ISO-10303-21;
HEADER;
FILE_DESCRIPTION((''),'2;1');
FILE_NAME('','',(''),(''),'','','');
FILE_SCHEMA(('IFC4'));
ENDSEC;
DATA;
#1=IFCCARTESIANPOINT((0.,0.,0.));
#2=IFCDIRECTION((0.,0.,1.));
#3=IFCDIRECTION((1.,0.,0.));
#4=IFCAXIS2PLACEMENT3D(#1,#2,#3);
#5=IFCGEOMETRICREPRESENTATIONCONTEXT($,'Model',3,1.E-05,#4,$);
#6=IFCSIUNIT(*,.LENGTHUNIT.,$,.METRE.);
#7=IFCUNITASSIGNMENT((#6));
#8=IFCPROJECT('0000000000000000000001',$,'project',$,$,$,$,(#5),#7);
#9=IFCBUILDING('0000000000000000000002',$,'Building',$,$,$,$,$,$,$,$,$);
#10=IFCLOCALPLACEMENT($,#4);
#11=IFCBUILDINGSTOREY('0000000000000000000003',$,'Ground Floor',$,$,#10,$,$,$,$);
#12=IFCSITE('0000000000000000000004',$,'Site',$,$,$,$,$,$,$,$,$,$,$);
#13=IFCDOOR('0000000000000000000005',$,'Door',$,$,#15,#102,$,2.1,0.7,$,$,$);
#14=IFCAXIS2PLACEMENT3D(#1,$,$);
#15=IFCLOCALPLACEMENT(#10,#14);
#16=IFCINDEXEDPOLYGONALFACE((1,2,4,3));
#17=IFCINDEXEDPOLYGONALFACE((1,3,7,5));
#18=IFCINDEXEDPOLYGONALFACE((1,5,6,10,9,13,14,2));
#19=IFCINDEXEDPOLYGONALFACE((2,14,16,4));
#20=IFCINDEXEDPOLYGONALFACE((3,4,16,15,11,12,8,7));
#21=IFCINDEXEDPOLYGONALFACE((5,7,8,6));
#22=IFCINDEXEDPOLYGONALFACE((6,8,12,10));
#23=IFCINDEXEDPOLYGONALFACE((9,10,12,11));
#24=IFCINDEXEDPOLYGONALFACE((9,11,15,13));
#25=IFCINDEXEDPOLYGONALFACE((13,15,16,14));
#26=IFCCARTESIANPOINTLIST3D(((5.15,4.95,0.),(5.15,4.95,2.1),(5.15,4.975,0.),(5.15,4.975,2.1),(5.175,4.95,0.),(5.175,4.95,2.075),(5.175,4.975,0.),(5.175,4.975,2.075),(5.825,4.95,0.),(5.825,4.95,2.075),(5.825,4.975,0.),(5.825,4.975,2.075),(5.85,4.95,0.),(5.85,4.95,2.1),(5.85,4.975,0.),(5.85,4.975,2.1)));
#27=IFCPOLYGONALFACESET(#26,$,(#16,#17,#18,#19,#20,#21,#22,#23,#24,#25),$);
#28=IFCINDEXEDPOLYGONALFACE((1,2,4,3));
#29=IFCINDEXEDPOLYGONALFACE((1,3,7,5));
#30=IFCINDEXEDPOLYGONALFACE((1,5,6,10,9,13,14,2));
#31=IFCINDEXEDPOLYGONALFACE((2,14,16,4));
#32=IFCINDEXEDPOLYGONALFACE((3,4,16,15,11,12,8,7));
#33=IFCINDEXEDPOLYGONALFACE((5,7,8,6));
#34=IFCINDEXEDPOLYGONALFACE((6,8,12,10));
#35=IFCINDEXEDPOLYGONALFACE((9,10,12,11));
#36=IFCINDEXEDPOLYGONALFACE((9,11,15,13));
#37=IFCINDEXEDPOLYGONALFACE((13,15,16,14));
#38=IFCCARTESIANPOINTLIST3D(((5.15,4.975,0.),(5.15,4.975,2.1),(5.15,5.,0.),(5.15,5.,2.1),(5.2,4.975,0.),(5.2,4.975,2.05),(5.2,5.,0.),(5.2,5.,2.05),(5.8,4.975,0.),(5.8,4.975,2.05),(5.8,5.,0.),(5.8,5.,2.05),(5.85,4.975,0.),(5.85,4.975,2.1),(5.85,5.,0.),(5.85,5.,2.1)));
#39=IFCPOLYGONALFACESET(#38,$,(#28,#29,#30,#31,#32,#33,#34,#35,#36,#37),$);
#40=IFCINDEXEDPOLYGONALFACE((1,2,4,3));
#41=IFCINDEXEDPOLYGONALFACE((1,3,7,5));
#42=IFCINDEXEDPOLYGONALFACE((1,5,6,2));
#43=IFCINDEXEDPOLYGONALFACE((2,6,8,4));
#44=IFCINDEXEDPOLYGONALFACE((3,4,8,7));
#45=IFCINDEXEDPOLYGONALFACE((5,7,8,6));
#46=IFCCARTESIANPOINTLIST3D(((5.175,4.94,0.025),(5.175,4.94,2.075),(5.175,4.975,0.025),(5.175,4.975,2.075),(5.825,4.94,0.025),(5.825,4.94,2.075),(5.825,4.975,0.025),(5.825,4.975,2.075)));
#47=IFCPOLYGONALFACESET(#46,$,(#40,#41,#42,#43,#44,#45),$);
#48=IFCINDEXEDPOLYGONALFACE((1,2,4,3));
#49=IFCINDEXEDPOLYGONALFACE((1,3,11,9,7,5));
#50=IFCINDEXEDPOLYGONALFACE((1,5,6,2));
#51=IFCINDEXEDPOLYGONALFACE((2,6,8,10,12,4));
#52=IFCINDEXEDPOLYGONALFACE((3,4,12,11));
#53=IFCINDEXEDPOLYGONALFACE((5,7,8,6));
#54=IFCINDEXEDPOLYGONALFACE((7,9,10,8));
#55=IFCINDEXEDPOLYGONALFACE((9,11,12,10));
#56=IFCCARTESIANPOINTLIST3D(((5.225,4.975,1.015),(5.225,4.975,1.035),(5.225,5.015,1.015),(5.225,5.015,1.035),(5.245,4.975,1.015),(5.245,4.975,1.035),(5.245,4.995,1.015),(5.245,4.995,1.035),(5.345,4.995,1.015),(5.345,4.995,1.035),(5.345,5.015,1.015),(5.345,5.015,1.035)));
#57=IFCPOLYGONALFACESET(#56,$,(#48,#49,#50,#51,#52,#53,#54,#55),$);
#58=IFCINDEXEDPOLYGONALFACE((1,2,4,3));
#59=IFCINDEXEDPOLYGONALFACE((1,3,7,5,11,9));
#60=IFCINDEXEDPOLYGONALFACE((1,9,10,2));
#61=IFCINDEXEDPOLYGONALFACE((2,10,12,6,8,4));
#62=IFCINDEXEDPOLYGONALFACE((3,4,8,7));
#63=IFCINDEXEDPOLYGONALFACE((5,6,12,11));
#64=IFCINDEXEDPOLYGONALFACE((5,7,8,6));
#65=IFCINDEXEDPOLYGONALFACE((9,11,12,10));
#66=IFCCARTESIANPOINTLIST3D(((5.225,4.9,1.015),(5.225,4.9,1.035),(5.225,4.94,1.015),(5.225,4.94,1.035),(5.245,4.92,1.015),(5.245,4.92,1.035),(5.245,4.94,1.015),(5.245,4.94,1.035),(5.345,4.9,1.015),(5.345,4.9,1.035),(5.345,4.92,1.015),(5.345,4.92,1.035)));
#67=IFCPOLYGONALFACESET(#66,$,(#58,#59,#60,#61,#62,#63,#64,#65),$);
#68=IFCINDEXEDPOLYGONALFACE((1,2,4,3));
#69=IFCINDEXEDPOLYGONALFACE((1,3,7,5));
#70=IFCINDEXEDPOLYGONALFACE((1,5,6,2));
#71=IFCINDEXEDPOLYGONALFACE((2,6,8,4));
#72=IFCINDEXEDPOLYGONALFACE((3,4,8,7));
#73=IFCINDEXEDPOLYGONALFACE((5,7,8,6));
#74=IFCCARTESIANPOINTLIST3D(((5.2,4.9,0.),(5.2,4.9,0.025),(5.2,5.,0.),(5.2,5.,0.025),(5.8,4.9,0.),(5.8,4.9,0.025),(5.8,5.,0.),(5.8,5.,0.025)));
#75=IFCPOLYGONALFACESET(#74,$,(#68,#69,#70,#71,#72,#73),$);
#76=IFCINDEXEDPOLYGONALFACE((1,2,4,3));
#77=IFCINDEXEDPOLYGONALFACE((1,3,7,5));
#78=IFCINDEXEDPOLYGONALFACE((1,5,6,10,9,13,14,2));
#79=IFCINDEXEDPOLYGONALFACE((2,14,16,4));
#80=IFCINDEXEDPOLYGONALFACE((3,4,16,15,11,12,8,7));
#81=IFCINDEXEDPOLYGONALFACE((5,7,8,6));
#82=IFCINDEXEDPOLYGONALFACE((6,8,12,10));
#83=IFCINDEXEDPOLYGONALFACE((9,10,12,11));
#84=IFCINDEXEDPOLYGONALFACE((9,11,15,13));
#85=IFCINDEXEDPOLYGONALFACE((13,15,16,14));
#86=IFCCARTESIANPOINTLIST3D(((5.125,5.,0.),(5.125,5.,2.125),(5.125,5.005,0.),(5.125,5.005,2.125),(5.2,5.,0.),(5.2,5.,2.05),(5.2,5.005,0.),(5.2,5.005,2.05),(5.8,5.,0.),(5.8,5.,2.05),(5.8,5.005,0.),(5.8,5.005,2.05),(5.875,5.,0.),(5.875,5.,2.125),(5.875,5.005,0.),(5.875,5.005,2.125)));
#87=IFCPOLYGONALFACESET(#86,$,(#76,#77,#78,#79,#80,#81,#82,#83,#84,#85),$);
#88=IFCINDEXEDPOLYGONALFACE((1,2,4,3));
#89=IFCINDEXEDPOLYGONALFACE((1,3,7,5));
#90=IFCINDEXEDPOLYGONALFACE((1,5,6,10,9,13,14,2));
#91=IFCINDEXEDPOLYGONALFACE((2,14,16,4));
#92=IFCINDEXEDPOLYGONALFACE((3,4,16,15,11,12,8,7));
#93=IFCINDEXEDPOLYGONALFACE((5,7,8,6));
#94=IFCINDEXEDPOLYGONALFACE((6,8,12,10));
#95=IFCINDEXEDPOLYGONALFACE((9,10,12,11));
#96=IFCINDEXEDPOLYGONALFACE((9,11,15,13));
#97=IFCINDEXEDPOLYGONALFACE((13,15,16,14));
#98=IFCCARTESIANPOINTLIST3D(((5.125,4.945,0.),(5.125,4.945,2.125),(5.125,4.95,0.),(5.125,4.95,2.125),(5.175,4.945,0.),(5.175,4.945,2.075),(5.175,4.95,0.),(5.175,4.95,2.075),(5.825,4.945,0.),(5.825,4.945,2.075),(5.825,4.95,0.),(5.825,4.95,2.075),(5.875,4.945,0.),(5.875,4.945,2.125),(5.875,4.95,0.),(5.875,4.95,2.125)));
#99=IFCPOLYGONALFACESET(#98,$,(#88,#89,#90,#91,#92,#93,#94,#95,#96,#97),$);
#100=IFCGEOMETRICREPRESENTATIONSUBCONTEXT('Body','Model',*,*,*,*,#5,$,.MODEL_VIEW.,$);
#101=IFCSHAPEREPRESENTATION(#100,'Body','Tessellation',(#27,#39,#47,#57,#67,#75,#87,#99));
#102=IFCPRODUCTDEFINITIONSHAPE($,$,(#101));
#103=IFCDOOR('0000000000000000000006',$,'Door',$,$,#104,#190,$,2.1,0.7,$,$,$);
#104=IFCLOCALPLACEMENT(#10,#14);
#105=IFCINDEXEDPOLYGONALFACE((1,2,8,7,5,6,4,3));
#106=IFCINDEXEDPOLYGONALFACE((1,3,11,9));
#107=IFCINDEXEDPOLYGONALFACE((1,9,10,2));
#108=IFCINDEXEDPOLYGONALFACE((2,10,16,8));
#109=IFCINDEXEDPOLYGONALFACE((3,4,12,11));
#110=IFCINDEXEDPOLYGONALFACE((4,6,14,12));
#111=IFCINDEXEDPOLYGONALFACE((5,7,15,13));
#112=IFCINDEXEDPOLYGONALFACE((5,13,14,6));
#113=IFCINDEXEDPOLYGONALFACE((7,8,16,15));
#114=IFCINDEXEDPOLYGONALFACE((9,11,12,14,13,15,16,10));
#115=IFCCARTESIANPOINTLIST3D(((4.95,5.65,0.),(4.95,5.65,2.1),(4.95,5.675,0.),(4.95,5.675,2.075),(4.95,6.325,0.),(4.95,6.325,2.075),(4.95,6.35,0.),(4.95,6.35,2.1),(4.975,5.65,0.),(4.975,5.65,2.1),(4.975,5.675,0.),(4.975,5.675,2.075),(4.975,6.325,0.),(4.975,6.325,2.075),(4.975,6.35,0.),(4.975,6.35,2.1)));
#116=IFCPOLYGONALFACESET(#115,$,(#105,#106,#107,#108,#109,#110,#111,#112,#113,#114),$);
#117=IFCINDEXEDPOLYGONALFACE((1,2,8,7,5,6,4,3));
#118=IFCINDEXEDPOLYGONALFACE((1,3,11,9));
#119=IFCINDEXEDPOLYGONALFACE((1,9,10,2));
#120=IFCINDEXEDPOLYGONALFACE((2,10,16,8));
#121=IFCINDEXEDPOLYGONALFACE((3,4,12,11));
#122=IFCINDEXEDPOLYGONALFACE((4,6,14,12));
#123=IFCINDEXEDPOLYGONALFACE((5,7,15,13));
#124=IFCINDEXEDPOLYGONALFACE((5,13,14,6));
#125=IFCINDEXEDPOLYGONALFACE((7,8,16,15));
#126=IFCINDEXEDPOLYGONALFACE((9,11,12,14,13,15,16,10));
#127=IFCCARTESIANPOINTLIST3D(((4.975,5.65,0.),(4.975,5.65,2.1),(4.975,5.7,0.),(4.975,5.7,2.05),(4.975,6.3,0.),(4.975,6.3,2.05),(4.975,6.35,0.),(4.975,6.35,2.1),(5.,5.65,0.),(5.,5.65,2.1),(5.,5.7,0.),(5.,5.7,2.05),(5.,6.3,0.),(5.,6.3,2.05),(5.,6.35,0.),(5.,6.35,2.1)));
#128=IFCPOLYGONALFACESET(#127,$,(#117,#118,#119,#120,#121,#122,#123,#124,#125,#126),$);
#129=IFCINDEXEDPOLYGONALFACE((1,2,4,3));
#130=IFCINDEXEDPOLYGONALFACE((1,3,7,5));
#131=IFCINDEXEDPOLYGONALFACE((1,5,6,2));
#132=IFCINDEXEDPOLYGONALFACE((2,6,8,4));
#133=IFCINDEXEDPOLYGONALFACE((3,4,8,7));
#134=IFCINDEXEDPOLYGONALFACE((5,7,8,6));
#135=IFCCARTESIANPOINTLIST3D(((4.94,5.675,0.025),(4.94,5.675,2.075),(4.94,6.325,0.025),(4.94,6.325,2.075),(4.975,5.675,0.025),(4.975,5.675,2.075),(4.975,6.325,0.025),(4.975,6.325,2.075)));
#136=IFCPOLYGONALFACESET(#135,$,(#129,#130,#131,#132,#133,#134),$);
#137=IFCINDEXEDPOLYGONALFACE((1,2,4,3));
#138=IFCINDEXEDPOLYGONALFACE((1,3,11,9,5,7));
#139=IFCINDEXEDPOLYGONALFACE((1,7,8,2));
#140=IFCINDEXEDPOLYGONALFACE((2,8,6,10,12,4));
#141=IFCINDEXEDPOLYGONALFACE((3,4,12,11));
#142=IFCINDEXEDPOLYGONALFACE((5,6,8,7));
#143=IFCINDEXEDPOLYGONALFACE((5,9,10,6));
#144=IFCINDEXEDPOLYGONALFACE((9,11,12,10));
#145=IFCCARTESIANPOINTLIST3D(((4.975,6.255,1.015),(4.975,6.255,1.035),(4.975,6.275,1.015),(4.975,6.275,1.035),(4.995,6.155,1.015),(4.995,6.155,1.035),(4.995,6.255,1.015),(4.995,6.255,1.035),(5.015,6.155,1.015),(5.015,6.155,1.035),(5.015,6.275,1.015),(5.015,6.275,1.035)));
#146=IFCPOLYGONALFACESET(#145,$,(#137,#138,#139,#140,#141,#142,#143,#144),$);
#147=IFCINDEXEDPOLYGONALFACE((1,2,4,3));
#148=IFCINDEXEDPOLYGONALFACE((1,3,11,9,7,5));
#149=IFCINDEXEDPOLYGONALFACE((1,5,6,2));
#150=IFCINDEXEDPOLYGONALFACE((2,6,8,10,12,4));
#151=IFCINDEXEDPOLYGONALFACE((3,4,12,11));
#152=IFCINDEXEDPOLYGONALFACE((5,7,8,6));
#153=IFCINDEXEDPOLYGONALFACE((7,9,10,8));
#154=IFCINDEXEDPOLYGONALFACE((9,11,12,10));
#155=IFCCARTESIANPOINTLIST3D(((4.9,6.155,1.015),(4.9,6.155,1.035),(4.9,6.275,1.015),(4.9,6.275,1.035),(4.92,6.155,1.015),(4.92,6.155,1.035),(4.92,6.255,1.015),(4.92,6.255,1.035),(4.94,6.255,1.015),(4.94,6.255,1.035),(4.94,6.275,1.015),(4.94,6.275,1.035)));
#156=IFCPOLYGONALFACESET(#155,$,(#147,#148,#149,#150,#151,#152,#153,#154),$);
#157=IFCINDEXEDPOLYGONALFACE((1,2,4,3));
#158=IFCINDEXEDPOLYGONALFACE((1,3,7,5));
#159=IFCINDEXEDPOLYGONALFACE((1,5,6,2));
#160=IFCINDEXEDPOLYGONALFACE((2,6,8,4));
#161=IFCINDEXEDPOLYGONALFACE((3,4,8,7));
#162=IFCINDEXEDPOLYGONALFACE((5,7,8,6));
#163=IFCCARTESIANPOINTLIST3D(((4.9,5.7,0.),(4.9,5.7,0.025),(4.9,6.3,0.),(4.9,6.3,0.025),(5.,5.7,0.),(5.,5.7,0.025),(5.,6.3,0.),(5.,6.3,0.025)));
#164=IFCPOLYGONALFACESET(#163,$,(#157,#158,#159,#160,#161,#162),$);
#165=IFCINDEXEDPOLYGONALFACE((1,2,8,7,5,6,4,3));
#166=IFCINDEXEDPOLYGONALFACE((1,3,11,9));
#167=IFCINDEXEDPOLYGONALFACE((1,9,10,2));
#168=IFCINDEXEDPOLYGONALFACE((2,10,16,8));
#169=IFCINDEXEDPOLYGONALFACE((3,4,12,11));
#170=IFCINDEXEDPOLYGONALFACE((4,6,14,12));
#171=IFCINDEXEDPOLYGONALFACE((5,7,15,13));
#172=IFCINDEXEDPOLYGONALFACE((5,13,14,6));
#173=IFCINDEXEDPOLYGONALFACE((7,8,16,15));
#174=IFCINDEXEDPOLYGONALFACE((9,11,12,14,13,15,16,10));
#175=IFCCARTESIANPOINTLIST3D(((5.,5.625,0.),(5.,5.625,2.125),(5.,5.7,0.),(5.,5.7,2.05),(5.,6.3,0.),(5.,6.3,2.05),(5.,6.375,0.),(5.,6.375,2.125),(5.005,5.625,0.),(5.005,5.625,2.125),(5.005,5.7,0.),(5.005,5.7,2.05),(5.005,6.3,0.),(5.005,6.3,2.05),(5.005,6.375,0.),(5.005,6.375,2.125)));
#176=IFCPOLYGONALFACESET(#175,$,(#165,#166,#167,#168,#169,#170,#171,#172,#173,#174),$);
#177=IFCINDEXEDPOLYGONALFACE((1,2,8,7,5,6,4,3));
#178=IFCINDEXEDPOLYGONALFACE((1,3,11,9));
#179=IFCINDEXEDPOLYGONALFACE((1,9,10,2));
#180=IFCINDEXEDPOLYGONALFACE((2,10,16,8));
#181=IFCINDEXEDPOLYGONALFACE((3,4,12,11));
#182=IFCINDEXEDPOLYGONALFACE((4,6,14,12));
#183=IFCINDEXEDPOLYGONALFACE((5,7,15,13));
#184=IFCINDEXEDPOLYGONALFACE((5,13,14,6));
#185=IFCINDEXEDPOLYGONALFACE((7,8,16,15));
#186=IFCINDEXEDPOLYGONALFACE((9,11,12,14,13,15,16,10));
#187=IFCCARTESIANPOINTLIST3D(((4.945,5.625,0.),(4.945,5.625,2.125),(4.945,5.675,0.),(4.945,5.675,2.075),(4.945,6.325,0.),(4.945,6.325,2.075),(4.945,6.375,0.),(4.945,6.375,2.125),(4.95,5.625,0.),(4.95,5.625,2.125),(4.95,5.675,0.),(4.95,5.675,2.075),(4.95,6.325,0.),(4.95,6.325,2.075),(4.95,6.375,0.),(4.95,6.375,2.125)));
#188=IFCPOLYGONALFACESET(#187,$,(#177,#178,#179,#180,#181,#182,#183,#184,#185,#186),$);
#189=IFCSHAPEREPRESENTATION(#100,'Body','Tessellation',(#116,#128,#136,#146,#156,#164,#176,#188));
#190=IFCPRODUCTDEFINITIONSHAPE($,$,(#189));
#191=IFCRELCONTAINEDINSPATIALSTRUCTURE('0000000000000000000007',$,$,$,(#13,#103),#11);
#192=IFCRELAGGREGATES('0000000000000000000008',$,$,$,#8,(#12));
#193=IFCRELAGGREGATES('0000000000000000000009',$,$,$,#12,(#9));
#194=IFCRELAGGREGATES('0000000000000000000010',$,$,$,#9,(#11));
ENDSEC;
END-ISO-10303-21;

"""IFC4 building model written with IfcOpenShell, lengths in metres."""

from ifc_helpers import new_model, si_unit, frame, origin_with_axes, place, context, subcontext, project, spatial, line, indexed_curve, outline, extrude, element, save


model = new_model("IFC4")

# Units and contexts
model_context = context("Model", 3, precision=1e-05, world=origin_with_axes())
body_context = subcontext(model_context, "Body", "Model", "MODEL_VIEW")
ifc_project = project(units=[si_unit("LENGTHUNIT", "METRE")], contexts=[model_context])

# Site, building, storey
site = spatial("IfcSite", under=ifc_project, Name="Site")
building = spatial("IfcBuilding", under=site, Name="Building")
storey_placement = place(None, origin_with_axes())
storey = spatial("IfcBuildingStorey", under=building, at=storey_placement, Name="Ground Floor")

# Doors
door_1_placement = place(storey_placement, frame((5.85, 5.0, 0.0), z_axis=(0.0, 0.0, 1.0), x_axis=(-1.0, 0.0, 0.0)))
element("IfcDoor", 1, at=door_1_placement, inside=storey, Name="Door", OverallHeight=2.1, OverallWidth=0.7, context=body_context, shape_type="SweptSolid", body=[
    extrude(outline(indexed_curve([(0.0, 0.0), (0.0, 2.1), (0.7, 2.1), (0.7, 0.0), (0.675, 0.0), (0.675, 2.075), (0.025, 2.075), (0.025, 0.0)], segments=[line(1, 2, 3, 4, 5, 6, 7, 8, 1)])), frame((0.0, 0.025, 0.0), z_axis=(0.0, -1.0, 0.0), x_axis=(1.0, 0.0, 0.0)), (0.0, 0.0, -1.0), 0.025),
    extrude(outline(indexed_curve([(0.0, 0.0), (0.0, 2.1), (0.7, 2.1), (0.7, 0.0), (0.65, 0.0), (0.65, 2.05), (0.05, 2.05), (0.05, 0.0)], segments=[line(1, 2, 3, 4, 5, 6, 7, 8, 1)])), frame((0.0, 0.0, 0.0), z_axis=(0.0, -1.0, 0.0), x_axis=(1.0, 0.0, 0.0)), (0.0, 0.0, -1.0), 0.025),
    extrude(outline(indexed_curve([(0.0, 0.0), (0.65, 0.0), (0.65, 0.035), (0.0, 0.035)], segments=[line(1, 2, 3, 4, 1)])), frame((0.025, 0.025, 0.025), z_axis=(0.0, 0.0, 1.0), x_axis=(1.0, 0.0, 0.0)), (0.0, 0.0, 1.0), 2.05),
    extrude(outline(indexed_curve([(0.0, 0.0), (0.0, -0.04), (-0.12, -0.04), (-0.12, -0.02), (-0.02, -0.02), (-0.02, 0.0)], segments=[line(1, 2, 3, 4, 5, 6, 1)])), frame((0.625, 0.025, 1.015), z_axis=(0.0, 0.0, 1.0), x_axis=(1.0, 0.0, 0.0)), (0.0, 0.0, 1.0), 0.02),
    extrude(outline(indexed_curve([(0.0, 0.0), (0.0, 0.04), (-0.12, 0.04), (-0.12, 0.02), (-0.02, 0.02), (-0.02, 0.0)], segments=[line(1, 2, 3, 4, 5, 6, 1)])), frame((0.625, 0.06, 1.015), z_axis=(0.0, 0.0, 1.0), x_axis=(1.0, 0.0, 0.0)), (0.0, 0.0, 1.0), 0.02),
    extrude(outline(indexed_curve([(0.0, 0.0), (0.6, 0.0), (0.6, 0.1), (0.0, 0.1)], segments=[line(1, 2, 3, 4, 1)])), frame((0.05, 0.0, 0.0), z_axis=(0.0, 0.0, 1.0), x_axis=(1.0, 0.0, 0.0)), (0.0, 0.0, 1.0), 0.025),
    extrude(outline(indexed_curve([(0.0, 0.0), (0.0, 2.125), (0.75, 2.125), (0.75, 0.0), (0.675, 0.0), (0.675, 2.05), (0.075, 2.05), (0.075, 0.0)], segments=[line(1, 2, 3, 4, 5, 6, 7, 8, 1)])), frame((-0.025, -0.005, 0.0), z_axis=(0.0, -1.0, 0.0), x_axis=(1.0, 0.0, 0.0)), (0.0, 0.0, -1.0), 0.005),
    extrude(outline(indexed_curve([(0.0, 0.0), (0.0, 2.125), (0.75, 2.125), (0.75, 0.0), (0.7, 0.0), (0.7, 2.075), (0.05, 2.075), (0.05, 0.0)], segments=[line(1, 2, 3, 4, 5, 6, 7, 8, 1)])), frame((-0.025, 0.05, 0.0), z_axis=(0.0, -1.0, 0.0), x_axis=(1.0, 0.0, 0.0)), (0.0, 0.0, -1.0), 0.005),
])
door_2_placement = place(storey_placement, frame((5.0, 5.65, 0.0), z_axis=(0.0, 0.0, 1.0), x_axis=(0.0, 1.0, 0.0)))
element("IfcDoor", 2, at=door_2_placement, inside=storey, Name="Door", OverallHeight=2.1, OverallWidth=0.7, context=body_context, shape_type="SweptSolid", body=[
    extrude(outline(indexed_curve([(0.0, 0.0), (0.0, 2.1), (0.7, 2.1), (0.7, 0.0), (0.675, 0.0), (0.675, 2.075), (0.025, 2.075), (0.025, 0.0)], segments=[line(1, 2, 3, 4, 5, 6, 7, 8, 1)])), frame((0.0, 0.025, 0.0), z_axis=(0.0, -1.0, 0.0), x_axis=(1.0, 0.0, 0.0)), (0.0, 0.0, -1.0), 0.025),
    extrude(outline(indexed_curve([(0.0, 0.0), (0.0, 2.1), (0.7, 2.1), (0.7, 0.0), (0.65, 0.0), (0.65, 2.05), (0.05, 2.05), (0.05, 0.0)], segments=[line(1, 2, 3, 4, 5, 6, 7, 8, 1)])), frame((0.0, 0.0, 0.0), z_axis=(0.0, -1.0, 0.0), x_axis=(1.0, 0.0, 0.0)), (0.0, 0.0, -1.0), 0.025),
    extrude(outline(indexed_curve([(0.0, 0.0), (0.65, 0.0), (0.65, 0.035), (0.0, 0.035)], segments=[line(1, 2, 3, 4, 1)])), frame((0.025, 0.025, 0.025), z_axis=(0.0, 0.0, 1.0), x_axis=(1.0, 0.0, 0.0)), (0.0, 0.0, 1.0), 2.05),
    extrude(outline(indexed_curve([(0.0, 0.0), (0.0, -0.04), (-0.12, -0.04), (-0.12, -0.02), (-0.02, -0.02), (-0.02, 0.0)], segments=[line(1, 2, 3, 4, 5, 6, 1)])), frame((0.625, 0.025, 1.015), z_axis=(0.0, 0.0, 1.0), x_axis=(1.0, 0.0, 0.0)), (0.0, 0.0, 1.0), 0.02),
    extrude(outline(indexed_curve([(0.0, 0.0), (0.0, 0.04), (-0.12, 0.04), (-0.12, 0.02), (-0.02, 0.02), (-0.02, 0.0)], segments=[line(1, 2, 3, 4, 5, 6, 1)])), frame((0.625, 0.06, 1.015), z_axis=(0.0, 0.0, 1.0), x_axis=(1.0, 0.0, 0.0)), (0.0, 0.0, 1.0), 0.02),
    extrude(outline(indexed_curve([(0.0, 0.0), (0.6, 0.0), (0.6, 0.1), (0.0, 0.1)], segments=[line(1, 2, 3, 4, 1)])), frame((0.05, 0.0, 0.0), z_axis=(0.0, 0.0, 1.0), x_axis=(1.0, 0.0, 0.0)), (0.0, 0.0, 1.0), 0.025),
    extrude(outline(indexed_curve([(0.0, 0.0), (0.0, 2.125), (0.75, 2.125), (0.75, 0.0), (0.675, 0.0), (0.675, 2.05), (0.075, 2.05), (0.075, 0.0)], segments=[line(1, 2, 3, 4, 5, 6, 7, 8, 1)])), frame((-0.025, -0.005, 0.0), z_axis=(0.0, -1.0, 0.0), x_axis=(1.0, 0.0, 0.0)), (0.0, 0.0, -1.0), 0.005),
    extrude(outline(indexed_curve([(0.0, 0.0), (0.0, 2.125), (0.75, 2.125), (0.75, 0.0), (0.7, 0.0), (0.7, 2.075), (0.05, 2.075), (0.05, 0.0)], segments=[line(1, 2, 3, 4, 5, 6, 7, 8, 1)])), frame((-0.025, 0.05, 0.0), z_axis=(0.0, -1.0, 0.0), x_axis=(1.0, 0.0, 0.0)), (0.0, 0.0, -1.0), 0.005),
])

save(model, "model.ifc")
